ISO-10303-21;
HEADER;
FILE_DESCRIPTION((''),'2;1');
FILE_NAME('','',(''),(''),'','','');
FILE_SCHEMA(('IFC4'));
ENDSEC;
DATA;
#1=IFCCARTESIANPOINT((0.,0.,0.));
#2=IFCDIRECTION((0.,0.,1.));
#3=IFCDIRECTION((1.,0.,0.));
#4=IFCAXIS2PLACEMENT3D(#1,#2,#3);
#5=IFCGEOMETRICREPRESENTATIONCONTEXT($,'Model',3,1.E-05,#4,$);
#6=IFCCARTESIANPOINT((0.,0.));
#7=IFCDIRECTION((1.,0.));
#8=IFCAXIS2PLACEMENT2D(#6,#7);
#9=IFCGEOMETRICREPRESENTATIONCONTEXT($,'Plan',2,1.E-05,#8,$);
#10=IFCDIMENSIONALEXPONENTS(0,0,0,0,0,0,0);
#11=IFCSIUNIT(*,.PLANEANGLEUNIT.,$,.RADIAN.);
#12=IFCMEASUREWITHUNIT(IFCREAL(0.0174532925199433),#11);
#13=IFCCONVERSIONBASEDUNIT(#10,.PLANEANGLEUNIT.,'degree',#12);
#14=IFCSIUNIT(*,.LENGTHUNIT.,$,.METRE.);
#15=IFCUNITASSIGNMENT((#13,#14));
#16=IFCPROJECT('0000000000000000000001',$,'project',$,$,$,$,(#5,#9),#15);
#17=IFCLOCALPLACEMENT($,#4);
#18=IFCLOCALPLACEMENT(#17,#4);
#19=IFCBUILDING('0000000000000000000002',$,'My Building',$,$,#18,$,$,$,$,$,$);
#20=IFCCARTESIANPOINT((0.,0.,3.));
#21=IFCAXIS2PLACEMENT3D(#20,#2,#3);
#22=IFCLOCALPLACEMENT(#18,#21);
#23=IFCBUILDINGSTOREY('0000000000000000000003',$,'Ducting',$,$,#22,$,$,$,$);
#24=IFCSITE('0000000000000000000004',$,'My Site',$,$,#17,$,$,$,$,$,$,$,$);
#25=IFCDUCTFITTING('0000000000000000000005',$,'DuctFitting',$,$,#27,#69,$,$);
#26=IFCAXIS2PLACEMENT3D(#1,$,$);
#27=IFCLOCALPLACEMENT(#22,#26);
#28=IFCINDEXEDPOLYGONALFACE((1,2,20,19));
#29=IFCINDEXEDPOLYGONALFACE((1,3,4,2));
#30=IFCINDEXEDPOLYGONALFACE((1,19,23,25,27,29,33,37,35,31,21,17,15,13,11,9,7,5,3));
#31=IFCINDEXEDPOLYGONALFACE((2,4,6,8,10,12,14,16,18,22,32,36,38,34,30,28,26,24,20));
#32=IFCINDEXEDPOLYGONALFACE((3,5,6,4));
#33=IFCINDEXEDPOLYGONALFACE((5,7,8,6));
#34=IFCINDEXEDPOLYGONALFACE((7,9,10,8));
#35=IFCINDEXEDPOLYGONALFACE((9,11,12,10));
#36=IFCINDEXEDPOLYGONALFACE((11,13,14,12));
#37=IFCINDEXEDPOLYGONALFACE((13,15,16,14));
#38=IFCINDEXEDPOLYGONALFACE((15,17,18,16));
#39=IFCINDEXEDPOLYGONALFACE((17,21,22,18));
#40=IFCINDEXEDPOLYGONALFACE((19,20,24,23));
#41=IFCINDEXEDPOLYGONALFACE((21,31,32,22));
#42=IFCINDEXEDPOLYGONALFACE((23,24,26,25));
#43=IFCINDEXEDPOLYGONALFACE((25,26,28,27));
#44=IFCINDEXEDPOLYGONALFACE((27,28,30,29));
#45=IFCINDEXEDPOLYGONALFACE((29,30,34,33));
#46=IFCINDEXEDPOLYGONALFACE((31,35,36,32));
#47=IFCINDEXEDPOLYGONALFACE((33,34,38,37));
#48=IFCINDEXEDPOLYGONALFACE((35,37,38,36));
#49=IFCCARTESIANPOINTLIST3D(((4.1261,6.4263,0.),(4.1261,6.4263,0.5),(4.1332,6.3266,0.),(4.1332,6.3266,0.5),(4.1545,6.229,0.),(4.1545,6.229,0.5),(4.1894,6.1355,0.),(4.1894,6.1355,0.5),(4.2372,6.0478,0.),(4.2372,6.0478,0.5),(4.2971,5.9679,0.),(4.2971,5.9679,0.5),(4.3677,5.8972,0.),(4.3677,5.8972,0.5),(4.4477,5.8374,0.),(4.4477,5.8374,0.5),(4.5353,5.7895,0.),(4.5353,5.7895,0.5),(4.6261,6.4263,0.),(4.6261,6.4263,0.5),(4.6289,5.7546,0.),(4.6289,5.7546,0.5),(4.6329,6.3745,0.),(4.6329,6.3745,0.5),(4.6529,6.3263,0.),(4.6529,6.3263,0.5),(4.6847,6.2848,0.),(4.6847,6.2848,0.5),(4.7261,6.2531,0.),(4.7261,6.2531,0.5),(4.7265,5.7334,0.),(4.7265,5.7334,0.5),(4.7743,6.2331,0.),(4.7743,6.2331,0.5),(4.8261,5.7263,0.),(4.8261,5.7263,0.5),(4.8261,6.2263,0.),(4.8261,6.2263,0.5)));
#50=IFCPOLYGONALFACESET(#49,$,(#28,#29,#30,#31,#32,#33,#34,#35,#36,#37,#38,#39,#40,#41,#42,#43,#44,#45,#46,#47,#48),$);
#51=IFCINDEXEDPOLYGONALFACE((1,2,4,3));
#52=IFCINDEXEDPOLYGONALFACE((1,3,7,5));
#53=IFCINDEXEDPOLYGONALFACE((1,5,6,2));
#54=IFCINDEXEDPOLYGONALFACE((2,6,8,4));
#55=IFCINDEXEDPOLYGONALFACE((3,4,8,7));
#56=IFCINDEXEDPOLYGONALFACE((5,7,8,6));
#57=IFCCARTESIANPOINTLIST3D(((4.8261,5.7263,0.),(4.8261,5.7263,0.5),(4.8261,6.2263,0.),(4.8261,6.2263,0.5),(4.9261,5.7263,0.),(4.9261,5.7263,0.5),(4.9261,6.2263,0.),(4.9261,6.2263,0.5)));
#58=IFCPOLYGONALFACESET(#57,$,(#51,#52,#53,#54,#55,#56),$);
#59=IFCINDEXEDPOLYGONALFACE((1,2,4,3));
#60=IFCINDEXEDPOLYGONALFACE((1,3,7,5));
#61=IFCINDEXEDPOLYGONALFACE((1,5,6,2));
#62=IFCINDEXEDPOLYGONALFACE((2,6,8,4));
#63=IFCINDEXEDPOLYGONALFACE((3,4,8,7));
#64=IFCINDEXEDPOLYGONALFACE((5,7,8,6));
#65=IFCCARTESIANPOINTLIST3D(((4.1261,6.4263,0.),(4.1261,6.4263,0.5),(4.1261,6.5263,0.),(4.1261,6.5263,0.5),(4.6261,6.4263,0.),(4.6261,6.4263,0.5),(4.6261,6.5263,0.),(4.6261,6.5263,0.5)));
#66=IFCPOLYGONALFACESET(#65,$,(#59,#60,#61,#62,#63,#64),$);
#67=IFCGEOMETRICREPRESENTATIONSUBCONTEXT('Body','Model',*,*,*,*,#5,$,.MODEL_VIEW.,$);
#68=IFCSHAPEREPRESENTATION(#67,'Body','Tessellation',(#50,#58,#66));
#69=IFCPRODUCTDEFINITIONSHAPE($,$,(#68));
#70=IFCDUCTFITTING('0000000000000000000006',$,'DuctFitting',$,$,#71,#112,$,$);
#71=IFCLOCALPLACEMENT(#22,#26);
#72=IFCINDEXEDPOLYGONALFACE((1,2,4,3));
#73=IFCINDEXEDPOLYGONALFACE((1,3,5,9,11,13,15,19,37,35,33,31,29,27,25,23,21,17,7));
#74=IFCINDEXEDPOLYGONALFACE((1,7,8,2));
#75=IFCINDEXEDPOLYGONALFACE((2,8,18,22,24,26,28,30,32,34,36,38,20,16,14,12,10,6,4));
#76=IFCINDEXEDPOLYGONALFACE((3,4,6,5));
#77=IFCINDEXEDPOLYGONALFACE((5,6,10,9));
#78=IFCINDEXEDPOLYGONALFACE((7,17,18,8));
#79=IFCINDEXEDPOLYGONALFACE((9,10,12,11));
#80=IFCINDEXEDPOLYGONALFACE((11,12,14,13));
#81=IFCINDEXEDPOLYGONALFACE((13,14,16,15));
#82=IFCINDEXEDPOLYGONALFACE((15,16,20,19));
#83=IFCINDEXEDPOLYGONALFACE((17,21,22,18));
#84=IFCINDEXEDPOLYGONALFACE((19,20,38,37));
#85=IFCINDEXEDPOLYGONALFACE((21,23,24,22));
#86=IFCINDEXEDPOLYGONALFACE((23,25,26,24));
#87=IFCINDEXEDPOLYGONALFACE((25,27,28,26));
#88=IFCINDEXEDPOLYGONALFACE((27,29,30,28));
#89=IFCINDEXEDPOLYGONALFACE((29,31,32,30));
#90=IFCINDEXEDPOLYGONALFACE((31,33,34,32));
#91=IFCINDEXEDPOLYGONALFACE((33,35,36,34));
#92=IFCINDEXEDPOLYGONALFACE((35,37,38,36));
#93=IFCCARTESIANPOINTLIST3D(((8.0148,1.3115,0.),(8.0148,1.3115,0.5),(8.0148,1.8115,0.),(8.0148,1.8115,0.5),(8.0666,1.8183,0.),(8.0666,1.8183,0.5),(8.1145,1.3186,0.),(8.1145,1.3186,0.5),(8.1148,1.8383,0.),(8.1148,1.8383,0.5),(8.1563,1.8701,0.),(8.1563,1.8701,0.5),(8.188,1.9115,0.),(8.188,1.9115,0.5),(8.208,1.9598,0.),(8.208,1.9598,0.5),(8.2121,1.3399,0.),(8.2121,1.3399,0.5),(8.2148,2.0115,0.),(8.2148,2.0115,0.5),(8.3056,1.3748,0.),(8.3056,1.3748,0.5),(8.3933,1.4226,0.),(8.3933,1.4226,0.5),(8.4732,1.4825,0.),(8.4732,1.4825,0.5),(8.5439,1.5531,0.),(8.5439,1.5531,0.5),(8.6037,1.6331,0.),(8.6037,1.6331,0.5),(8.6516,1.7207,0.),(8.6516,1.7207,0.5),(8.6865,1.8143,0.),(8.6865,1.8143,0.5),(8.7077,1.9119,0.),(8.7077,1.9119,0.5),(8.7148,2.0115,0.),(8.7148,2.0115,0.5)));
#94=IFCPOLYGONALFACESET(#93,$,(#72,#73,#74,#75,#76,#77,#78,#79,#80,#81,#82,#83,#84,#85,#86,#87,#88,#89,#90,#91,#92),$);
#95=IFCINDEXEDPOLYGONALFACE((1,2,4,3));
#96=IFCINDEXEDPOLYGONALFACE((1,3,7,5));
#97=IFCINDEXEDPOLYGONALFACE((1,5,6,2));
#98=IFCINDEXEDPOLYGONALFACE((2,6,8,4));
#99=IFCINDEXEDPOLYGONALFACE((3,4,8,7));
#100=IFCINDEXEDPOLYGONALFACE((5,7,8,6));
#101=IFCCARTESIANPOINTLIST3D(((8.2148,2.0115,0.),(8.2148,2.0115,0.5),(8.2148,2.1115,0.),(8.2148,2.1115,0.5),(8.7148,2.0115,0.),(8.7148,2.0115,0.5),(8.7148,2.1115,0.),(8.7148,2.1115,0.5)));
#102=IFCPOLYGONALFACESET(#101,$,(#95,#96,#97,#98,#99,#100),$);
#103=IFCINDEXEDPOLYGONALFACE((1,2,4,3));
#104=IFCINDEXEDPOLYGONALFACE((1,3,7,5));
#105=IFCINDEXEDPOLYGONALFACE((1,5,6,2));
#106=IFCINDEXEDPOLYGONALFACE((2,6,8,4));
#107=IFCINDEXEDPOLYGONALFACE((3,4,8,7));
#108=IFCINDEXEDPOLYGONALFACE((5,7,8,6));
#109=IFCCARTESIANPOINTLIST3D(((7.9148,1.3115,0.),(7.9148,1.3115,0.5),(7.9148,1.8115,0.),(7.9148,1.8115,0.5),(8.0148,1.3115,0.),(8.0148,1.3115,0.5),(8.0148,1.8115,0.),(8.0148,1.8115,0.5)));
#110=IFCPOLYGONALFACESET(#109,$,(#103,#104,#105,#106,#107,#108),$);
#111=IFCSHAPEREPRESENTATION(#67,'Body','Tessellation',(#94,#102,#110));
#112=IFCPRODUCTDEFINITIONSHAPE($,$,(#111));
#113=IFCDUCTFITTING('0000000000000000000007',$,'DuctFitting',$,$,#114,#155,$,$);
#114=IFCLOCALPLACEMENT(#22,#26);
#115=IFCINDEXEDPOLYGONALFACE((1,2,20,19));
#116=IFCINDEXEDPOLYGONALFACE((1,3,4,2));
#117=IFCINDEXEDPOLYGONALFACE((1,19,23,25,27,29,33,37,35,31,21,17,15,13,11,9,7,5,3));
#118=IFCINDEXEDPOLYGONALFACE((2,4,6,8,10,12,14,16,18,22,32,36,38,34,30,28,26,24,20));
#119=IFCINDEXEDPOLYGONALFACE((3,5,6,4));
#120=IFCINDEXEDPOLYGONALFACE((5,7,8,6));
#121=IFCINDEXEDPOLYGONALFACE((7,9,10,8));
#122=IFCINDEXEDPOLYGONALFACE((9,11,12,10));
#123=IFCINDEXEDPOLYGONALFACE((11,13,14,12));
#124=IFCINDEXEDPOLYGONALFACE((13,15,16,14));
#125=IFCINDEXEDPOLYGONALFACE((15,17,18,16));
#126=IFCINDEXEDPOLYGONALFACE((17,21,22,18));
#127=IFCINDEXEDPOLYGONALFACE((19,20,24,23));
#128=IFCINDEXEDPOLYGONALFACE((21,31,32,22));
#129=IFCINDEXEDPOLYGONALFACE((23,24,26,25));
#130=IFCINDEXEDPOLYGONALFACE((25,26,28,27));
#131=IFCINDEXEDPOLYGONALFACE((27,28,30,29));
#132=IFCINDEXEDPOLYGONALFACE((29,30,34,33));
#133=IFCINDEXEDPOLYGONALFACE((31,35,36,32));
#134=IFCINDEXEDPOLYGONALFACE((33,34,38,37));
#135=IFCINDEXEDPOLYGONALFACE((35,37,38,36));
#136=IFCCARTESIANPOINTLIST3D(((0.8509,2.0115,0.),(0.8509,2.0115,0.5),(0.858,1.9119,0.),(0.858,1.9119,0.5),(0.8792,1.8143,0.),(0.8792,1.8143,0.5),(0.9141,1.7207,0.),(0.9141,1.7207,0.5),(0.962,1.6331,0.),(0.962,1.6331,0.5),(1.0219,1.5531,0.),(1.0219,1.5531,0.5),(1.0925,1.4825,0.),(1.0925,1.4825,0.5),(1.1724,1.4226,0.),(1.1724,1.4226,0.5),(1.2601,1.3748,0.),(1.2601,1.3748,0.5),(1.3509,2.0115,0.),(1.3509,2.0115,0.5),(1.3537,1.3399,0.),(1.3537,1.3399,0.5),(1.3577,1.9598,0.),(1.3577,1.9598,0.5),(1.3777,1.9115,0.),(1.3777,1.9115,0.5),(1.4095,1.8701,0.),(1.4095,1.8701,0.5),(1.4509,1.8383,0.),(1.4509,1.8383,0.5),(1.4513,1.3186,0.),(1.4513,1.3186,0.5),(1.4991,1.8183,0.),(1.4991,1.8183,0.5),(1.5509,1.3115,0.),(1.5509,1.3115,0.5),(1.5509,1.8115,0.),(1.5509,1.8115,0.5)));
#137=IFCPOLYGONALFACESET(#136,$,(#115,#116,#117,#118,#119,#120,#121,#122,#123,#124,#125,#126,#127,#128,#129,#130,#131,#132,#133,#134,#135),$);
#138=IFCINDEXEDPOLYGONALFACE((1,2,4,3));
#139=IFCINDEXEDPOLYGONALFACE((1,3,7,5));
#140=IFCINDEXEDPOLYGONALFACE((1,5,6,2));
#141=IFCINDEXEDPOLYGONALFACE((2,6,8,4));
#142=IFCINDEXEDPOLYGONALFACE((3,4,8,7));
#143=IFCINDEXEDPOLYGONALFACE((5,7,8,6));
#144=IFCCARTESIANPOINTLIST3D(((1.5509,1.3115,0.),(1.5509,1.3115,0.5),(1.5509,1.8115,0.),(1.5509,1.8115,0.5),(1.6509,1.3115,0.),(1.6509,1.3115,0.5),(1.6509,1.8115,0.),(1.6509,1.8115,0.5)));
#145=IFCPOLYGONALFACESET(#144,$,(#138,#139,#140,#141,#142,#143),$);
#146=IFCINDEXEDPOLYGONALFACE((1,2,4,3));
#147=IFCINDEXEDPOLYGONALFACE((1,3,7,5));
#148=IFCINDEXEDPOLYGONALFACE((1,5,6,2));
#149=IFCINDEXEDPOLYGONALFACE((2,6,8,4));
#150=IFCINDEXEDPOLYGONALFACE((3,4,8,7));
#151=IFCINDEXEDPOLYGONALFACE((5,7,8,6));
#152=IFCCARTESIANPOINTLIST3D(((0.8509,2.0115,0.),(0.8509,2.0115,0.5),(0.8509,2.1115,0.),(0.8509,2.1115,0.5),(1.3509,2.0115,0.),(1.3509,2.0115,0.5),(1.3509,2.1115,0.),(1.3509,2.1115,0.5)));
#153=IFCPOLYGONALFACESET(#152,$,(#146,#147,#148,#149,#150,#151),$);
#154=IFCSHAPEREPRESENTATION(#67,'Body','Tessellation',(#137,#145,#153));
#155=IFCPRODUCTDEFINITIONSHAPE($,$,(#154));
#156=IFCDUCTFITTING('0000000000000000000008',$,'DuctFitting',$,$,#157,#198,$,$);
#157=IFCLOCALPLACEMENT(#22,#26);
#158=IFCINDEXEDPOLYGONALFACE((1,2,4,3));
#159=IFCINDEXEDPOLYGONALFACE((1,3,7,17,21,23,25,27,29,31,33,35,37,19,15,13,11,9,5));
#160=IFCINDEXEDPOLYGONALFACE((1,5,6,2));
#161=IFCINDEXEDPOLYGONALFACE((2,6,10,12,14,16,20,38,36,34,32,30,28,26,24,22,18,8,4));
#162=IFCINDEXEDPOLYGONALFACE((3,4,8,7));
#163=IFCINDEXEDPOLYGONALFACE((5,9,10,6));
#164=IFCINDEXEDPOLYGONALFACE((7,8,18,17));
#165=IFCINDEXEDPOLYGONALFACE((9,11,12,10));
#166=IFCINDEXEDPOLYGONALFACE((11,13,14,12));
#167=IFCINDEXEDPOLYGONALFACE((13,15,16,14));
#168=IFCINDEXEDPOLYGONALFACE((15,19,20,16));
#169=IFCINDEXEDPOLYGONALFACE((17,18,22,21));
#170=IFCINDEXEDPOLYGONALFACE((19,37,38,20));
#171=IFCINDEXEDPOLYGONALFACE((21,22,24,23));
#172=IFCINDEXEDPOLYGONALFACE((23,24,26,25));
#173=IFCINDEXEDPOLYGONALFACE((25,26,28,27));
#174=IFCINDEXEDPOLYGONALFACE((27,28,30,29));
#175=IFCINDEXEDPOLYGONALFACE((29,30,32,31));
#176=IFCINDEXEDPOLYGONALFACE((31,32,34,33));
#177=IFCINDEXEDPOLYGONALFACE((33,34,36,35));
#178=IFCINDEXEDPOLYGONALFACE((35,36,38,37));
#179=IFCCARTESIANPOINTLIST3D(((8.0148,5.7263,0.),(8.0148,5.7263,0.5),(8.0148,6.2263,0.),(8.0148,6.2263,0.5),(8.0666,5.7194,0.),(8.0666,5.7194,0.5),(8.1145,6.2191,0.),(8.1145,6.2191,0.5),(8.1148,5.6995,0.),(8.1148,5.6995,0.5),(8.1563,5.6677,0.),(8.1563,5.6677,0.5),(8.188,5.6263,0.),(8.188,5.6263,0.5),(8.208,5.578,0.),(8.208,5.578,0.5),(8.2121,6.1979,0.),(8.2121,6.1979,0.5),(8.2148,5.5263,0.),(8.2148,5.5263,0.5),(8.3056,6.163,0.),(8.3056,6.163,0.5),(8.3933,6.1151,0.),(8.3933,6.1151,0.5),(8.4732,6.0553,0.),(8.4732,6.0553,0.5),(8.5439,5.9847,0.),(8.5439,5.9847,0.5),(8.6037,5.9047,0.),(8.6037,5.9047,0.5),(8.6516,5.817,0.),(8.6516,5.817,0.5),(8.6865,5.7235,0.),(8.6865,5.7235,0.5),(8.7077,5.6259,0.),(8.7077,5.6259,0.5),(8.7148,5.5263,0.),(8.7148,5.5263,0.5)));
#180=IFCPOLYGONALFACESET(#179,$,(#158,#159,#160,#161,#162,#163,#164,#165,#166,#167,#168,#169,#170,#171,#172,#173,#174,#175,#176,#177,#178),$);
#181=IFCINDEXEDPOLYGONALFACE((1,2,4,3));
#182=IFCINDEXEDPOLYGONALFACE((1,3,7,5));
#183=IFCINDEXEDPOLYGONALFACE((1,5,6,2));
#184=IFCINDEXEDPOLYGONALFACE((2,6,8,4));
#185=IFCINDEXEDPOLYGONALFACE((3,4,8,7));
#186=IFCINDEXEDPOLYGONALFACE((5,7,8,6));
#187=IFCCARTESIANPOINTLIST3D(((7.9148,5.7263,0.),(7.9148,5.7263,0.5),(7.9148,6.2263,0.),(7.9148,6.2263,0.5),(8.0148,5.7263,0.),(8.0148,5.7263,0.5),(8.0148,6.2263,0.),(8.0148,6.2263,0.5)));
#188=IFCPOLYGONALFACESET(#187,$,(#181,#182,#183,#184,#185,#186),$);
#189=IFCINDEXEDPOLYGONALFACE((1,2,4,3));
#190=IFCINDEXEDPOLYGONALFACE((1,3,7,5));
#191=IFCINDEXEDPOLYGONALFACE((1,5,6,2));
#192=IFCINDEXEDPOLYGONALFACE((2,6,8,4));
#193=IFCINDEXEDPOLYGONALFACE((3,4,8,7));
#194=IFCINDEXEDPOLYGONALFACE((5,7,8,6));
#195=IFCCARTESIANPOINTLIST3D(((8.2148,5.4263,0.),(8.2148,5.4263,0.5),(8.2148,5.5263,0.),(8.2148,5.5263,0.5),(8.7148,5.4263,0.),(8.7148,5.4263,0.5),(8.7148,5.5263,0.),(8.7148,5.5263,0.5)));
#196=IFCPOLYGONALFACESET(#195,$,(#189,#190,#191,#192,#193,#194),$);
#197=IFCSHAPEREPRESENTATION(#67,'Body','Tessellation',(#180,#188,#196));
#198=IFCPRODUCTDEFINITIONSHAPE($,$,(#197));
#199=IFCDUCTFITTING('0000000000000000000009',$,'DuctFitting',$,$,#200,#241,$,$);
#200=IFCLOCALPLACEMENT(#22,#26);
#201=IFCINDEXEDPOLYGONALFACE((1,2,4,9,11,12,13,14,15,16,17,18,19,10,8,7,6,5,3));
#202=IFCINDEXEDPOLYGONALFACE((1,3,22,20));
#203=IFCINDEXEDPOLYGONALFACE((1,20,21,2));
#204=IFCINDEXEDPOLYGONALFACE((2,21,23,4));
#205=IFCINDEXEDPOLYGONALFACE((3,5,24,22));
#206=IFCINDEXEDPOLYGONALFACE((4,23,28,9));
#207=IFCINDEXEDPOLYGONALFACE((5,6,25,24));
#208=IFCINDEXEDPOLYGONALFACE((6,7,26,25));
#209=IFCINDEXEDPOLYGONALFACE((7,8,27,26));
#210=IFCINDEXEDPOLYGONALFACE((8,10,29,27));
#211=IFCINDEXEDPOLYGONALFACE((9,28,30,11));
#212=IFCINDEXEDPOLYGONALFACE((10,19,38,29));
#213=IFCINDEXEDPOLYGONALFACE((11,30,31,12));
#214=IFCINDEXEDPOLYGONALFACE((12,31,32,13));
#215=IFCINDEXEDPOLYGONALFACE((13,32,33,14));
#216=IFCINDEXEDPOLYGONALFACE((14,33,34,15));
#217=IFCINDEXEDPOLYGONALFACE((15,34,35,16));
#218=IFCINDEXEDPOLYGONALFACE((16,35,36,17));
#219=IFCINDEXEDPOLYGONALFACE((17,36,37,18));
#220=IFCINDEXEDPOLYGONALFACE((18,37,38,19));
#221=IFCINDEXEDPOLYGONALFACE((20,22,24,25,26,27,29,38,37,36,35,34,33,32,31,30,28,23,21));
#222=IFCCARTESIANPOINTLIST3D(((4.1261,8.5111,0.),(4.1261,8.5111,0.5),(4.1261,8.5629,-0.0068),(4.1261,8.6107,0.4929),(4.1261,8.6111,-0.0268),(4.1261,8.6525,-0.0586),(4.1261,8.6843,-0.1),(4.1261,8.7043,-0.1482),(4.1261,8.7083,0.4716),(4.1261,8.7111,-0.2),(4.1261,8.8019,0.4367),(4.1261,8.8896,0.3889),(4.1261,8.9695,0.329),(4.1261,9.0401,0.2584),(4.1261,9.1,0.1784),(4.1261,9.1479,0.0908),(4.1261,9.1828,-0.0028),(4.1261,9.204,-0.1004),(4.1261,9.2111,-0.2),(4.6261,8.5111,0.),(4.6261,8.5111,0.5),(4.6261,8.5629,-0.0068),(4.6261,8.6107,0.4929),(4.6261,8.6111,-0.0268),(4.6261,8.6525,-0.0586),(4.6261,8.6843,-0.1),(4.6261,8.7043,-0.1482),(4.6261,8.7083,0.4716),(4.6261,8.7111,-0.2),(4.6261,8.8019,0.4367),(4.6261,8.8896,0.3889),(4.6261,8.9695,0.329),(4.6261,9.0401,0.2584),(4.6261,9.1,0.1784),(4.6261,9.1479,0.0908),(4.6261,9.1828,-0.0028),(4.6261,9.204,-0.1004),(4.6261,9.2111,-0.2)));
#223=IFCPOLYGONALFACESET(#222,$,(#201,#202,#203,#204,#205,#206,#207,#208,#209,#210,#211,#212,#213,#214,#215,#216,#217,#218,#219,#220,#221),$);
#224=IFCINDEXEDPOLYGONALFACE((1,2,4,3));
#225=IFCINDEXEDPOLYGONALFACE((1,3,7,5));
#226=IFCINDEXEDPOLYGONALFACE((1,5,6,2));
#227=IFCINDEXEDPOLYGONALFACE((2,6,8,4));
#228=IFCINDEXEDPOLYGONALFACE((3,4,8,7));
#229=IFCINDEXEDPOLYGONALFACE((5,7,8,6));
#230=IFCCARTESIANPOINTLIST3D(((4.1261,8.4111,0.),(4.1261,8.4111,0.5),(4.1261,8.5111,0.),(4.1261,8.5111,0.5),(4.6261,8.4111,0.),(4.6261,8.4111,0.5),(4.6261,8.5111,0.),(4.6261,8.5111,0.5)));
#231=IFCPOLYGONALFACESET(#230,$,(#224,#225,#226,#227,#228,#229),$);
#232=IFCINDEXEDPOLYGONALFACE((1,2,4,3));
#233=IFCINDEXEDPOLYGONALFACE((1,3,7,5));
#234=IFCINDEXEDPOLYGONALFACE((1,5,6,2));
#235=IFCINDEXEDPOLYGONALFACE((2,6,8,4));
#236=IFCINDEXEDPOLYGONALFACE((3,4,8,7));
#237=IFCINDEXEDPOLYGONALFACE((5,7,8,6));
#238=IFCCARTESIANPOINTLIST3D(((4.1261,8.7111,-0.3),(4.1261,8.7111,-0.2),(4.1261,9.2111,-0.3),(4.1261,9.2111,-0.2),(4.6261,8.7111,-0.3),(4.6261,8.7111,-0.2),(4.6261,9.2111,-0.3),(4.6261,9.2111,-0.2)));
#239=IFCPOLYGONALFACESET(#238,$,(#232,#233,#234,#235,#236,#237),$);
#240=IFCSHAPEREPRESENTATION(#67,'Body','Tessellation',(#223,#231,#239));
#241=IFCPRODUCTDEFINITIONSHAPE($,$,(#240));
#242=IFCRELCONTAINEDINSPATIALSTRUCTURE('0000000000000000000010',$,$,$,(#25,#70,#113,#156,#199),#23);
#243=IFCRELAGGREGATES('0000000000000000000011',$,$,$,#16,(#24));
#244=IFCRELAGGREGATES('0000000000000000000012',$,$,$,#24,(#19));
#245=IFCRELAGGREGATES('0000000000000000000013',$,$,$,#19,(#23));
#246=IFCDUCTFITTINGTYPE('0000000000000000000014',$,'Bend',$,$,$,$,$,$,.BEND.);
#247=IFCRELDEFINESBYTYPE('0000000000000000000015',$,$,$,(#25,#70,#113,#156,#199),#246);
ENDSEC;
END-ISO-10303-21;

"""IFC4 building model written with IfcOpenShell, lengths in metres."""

from ifc_helpers import new_model, entity, si_unit, converted_unit, frame, origin_with_axes, origin_2d_with_axis, place, context, subcontext, project, spatial, line, arc, indexed_curve, rectangle, outline, extrude, source, transform, mapped, type_object, type_shapes, element, save


model = new_model("IFC4")

# Units and contexts
model_context = context("Model", 3, precision=1e-05, world=origin_with_axes())
plan_context = context("Plan", 2, precision=1e-05, world=origin_2d_with_axis())
body_context = subcontext(model_context, "Body", "Model", "MODEL_VIEW")
ifc_project = project(units=[converted_unit("PLANEANGLEUNIT", "degree", entity("IfcReal", 0.0174532925199433), si_unit("PLANEANGLEUNIT", "RADIAN"), dimensions=[0, 0, 0, 0, 0, 0, 0]), si_unit("LENGTHUNIT", "METRE")], contexts=[model_context, plan_context])

# Site, building, storey
site_placement = place(None, origin_with_axes())
site = spatial("IfcSite", under=ifc_project, at=site_placement, Name="My Site")
building_placement = place(site_placement, origin_with_axes())
building = spatial("IfcBuilding", under=site, at=building_placement, Name="My Building")
storey_placement = place(building_placement, frame((0.0, 0.0, 3.0), z_axis=(0.0, 0.0, 1.0), x_axis=(1.0, 0.0, 0.0)))
storey = spatial("IfcBuildingStorey", under=building, at=storey_placement, Name="Ducting")

# Duct fittings
duct_fitting_type_1 = type_object("IfcDuctFittingType", Name="Bend", PredefinedType="BEND")
shared_shape = source(origin_with_axes(), body_context, "Body", "SweptSolid", [
    extrude(outline(indexed_curve([(-0.25, 0.0), (-0.3086, 0.1414), (-0.45, 0.2), (-0.45, 0.7), (0.045, 0.495), (0.25, 0.0)], segments=[arc(1, 2, 3), line(3, 4), arc(4, 5, 6), line(6, 1)])), frame((0.0, -0.25, 0.1), z_axis=(0.0, -1.0, 0.0), x_axis=(1.0, 0.0, 0.0)), (0.0, 0.0, -1.0), 0.5),
    extrude(rectangle(XDim=0.5, YDim=0.5), origin_with_axes(), (0.0, 0.0, 1.0), 0.1),
    extrude(rectangle(XDim=0.5, YDim=0.5), frame((-0.45, 0.0, 0.55), z_axis=(-1.0, 0.0, 0.0), x_axis=(0.0, 0.0, -1.0)), (0.0, 0.0, 1.0), 0.1),
])
type_shapes(duct_fitting_type_1, [shared_shape])
for number, where, z_axis, x_axis, name in (
    (1, (4.9261, 5.9763, 0.25), (-1.0, 0.0, 0.0), (0.0, -1.0, 0.0), "DuctFitting"),
    (2, (8.4648, 2.1115, 0.25), (0.0, -1.0, 0.0), (1.0, 0.0, 0.0), "DuctFitting"),
    (3, (1.6509, 1.5615, 0.25), (-1.0, 0.0, 0.0), (0.0, -1.0, 0.0), "DuctFitting"),
    (4, (7.9148, 5.9763, 0.25), (1.0, 0.0, 0.0), (0.0, 1.0, 0.0), "DuctFitting"),
    (5, (4.3761, 8.4111, 0.25), (0.0, 1.0, 0.0), (0.0, 0.0, 1.0), "DuctFitting"),
):
    element("IfcDuctFitting", number, at=place(storey_placement, frame(where, z_axis=z_axis, x_axis=x_axis)), inside=storey, type_object=duct_fitting_type_1, Name=name, context=body_context, shape_type="MappedRepresentation", body=[
        mapped(shared_shape, transform((0.0, 0.0, 0.0), x_axis=(1.0, 0.0, 0.0), y_axis=(0.0, 1.0, 0.0), z_axis=(0.0, 0.0, 1.0), scale=1.0)),
    ])

save(model, "model.ifc")
